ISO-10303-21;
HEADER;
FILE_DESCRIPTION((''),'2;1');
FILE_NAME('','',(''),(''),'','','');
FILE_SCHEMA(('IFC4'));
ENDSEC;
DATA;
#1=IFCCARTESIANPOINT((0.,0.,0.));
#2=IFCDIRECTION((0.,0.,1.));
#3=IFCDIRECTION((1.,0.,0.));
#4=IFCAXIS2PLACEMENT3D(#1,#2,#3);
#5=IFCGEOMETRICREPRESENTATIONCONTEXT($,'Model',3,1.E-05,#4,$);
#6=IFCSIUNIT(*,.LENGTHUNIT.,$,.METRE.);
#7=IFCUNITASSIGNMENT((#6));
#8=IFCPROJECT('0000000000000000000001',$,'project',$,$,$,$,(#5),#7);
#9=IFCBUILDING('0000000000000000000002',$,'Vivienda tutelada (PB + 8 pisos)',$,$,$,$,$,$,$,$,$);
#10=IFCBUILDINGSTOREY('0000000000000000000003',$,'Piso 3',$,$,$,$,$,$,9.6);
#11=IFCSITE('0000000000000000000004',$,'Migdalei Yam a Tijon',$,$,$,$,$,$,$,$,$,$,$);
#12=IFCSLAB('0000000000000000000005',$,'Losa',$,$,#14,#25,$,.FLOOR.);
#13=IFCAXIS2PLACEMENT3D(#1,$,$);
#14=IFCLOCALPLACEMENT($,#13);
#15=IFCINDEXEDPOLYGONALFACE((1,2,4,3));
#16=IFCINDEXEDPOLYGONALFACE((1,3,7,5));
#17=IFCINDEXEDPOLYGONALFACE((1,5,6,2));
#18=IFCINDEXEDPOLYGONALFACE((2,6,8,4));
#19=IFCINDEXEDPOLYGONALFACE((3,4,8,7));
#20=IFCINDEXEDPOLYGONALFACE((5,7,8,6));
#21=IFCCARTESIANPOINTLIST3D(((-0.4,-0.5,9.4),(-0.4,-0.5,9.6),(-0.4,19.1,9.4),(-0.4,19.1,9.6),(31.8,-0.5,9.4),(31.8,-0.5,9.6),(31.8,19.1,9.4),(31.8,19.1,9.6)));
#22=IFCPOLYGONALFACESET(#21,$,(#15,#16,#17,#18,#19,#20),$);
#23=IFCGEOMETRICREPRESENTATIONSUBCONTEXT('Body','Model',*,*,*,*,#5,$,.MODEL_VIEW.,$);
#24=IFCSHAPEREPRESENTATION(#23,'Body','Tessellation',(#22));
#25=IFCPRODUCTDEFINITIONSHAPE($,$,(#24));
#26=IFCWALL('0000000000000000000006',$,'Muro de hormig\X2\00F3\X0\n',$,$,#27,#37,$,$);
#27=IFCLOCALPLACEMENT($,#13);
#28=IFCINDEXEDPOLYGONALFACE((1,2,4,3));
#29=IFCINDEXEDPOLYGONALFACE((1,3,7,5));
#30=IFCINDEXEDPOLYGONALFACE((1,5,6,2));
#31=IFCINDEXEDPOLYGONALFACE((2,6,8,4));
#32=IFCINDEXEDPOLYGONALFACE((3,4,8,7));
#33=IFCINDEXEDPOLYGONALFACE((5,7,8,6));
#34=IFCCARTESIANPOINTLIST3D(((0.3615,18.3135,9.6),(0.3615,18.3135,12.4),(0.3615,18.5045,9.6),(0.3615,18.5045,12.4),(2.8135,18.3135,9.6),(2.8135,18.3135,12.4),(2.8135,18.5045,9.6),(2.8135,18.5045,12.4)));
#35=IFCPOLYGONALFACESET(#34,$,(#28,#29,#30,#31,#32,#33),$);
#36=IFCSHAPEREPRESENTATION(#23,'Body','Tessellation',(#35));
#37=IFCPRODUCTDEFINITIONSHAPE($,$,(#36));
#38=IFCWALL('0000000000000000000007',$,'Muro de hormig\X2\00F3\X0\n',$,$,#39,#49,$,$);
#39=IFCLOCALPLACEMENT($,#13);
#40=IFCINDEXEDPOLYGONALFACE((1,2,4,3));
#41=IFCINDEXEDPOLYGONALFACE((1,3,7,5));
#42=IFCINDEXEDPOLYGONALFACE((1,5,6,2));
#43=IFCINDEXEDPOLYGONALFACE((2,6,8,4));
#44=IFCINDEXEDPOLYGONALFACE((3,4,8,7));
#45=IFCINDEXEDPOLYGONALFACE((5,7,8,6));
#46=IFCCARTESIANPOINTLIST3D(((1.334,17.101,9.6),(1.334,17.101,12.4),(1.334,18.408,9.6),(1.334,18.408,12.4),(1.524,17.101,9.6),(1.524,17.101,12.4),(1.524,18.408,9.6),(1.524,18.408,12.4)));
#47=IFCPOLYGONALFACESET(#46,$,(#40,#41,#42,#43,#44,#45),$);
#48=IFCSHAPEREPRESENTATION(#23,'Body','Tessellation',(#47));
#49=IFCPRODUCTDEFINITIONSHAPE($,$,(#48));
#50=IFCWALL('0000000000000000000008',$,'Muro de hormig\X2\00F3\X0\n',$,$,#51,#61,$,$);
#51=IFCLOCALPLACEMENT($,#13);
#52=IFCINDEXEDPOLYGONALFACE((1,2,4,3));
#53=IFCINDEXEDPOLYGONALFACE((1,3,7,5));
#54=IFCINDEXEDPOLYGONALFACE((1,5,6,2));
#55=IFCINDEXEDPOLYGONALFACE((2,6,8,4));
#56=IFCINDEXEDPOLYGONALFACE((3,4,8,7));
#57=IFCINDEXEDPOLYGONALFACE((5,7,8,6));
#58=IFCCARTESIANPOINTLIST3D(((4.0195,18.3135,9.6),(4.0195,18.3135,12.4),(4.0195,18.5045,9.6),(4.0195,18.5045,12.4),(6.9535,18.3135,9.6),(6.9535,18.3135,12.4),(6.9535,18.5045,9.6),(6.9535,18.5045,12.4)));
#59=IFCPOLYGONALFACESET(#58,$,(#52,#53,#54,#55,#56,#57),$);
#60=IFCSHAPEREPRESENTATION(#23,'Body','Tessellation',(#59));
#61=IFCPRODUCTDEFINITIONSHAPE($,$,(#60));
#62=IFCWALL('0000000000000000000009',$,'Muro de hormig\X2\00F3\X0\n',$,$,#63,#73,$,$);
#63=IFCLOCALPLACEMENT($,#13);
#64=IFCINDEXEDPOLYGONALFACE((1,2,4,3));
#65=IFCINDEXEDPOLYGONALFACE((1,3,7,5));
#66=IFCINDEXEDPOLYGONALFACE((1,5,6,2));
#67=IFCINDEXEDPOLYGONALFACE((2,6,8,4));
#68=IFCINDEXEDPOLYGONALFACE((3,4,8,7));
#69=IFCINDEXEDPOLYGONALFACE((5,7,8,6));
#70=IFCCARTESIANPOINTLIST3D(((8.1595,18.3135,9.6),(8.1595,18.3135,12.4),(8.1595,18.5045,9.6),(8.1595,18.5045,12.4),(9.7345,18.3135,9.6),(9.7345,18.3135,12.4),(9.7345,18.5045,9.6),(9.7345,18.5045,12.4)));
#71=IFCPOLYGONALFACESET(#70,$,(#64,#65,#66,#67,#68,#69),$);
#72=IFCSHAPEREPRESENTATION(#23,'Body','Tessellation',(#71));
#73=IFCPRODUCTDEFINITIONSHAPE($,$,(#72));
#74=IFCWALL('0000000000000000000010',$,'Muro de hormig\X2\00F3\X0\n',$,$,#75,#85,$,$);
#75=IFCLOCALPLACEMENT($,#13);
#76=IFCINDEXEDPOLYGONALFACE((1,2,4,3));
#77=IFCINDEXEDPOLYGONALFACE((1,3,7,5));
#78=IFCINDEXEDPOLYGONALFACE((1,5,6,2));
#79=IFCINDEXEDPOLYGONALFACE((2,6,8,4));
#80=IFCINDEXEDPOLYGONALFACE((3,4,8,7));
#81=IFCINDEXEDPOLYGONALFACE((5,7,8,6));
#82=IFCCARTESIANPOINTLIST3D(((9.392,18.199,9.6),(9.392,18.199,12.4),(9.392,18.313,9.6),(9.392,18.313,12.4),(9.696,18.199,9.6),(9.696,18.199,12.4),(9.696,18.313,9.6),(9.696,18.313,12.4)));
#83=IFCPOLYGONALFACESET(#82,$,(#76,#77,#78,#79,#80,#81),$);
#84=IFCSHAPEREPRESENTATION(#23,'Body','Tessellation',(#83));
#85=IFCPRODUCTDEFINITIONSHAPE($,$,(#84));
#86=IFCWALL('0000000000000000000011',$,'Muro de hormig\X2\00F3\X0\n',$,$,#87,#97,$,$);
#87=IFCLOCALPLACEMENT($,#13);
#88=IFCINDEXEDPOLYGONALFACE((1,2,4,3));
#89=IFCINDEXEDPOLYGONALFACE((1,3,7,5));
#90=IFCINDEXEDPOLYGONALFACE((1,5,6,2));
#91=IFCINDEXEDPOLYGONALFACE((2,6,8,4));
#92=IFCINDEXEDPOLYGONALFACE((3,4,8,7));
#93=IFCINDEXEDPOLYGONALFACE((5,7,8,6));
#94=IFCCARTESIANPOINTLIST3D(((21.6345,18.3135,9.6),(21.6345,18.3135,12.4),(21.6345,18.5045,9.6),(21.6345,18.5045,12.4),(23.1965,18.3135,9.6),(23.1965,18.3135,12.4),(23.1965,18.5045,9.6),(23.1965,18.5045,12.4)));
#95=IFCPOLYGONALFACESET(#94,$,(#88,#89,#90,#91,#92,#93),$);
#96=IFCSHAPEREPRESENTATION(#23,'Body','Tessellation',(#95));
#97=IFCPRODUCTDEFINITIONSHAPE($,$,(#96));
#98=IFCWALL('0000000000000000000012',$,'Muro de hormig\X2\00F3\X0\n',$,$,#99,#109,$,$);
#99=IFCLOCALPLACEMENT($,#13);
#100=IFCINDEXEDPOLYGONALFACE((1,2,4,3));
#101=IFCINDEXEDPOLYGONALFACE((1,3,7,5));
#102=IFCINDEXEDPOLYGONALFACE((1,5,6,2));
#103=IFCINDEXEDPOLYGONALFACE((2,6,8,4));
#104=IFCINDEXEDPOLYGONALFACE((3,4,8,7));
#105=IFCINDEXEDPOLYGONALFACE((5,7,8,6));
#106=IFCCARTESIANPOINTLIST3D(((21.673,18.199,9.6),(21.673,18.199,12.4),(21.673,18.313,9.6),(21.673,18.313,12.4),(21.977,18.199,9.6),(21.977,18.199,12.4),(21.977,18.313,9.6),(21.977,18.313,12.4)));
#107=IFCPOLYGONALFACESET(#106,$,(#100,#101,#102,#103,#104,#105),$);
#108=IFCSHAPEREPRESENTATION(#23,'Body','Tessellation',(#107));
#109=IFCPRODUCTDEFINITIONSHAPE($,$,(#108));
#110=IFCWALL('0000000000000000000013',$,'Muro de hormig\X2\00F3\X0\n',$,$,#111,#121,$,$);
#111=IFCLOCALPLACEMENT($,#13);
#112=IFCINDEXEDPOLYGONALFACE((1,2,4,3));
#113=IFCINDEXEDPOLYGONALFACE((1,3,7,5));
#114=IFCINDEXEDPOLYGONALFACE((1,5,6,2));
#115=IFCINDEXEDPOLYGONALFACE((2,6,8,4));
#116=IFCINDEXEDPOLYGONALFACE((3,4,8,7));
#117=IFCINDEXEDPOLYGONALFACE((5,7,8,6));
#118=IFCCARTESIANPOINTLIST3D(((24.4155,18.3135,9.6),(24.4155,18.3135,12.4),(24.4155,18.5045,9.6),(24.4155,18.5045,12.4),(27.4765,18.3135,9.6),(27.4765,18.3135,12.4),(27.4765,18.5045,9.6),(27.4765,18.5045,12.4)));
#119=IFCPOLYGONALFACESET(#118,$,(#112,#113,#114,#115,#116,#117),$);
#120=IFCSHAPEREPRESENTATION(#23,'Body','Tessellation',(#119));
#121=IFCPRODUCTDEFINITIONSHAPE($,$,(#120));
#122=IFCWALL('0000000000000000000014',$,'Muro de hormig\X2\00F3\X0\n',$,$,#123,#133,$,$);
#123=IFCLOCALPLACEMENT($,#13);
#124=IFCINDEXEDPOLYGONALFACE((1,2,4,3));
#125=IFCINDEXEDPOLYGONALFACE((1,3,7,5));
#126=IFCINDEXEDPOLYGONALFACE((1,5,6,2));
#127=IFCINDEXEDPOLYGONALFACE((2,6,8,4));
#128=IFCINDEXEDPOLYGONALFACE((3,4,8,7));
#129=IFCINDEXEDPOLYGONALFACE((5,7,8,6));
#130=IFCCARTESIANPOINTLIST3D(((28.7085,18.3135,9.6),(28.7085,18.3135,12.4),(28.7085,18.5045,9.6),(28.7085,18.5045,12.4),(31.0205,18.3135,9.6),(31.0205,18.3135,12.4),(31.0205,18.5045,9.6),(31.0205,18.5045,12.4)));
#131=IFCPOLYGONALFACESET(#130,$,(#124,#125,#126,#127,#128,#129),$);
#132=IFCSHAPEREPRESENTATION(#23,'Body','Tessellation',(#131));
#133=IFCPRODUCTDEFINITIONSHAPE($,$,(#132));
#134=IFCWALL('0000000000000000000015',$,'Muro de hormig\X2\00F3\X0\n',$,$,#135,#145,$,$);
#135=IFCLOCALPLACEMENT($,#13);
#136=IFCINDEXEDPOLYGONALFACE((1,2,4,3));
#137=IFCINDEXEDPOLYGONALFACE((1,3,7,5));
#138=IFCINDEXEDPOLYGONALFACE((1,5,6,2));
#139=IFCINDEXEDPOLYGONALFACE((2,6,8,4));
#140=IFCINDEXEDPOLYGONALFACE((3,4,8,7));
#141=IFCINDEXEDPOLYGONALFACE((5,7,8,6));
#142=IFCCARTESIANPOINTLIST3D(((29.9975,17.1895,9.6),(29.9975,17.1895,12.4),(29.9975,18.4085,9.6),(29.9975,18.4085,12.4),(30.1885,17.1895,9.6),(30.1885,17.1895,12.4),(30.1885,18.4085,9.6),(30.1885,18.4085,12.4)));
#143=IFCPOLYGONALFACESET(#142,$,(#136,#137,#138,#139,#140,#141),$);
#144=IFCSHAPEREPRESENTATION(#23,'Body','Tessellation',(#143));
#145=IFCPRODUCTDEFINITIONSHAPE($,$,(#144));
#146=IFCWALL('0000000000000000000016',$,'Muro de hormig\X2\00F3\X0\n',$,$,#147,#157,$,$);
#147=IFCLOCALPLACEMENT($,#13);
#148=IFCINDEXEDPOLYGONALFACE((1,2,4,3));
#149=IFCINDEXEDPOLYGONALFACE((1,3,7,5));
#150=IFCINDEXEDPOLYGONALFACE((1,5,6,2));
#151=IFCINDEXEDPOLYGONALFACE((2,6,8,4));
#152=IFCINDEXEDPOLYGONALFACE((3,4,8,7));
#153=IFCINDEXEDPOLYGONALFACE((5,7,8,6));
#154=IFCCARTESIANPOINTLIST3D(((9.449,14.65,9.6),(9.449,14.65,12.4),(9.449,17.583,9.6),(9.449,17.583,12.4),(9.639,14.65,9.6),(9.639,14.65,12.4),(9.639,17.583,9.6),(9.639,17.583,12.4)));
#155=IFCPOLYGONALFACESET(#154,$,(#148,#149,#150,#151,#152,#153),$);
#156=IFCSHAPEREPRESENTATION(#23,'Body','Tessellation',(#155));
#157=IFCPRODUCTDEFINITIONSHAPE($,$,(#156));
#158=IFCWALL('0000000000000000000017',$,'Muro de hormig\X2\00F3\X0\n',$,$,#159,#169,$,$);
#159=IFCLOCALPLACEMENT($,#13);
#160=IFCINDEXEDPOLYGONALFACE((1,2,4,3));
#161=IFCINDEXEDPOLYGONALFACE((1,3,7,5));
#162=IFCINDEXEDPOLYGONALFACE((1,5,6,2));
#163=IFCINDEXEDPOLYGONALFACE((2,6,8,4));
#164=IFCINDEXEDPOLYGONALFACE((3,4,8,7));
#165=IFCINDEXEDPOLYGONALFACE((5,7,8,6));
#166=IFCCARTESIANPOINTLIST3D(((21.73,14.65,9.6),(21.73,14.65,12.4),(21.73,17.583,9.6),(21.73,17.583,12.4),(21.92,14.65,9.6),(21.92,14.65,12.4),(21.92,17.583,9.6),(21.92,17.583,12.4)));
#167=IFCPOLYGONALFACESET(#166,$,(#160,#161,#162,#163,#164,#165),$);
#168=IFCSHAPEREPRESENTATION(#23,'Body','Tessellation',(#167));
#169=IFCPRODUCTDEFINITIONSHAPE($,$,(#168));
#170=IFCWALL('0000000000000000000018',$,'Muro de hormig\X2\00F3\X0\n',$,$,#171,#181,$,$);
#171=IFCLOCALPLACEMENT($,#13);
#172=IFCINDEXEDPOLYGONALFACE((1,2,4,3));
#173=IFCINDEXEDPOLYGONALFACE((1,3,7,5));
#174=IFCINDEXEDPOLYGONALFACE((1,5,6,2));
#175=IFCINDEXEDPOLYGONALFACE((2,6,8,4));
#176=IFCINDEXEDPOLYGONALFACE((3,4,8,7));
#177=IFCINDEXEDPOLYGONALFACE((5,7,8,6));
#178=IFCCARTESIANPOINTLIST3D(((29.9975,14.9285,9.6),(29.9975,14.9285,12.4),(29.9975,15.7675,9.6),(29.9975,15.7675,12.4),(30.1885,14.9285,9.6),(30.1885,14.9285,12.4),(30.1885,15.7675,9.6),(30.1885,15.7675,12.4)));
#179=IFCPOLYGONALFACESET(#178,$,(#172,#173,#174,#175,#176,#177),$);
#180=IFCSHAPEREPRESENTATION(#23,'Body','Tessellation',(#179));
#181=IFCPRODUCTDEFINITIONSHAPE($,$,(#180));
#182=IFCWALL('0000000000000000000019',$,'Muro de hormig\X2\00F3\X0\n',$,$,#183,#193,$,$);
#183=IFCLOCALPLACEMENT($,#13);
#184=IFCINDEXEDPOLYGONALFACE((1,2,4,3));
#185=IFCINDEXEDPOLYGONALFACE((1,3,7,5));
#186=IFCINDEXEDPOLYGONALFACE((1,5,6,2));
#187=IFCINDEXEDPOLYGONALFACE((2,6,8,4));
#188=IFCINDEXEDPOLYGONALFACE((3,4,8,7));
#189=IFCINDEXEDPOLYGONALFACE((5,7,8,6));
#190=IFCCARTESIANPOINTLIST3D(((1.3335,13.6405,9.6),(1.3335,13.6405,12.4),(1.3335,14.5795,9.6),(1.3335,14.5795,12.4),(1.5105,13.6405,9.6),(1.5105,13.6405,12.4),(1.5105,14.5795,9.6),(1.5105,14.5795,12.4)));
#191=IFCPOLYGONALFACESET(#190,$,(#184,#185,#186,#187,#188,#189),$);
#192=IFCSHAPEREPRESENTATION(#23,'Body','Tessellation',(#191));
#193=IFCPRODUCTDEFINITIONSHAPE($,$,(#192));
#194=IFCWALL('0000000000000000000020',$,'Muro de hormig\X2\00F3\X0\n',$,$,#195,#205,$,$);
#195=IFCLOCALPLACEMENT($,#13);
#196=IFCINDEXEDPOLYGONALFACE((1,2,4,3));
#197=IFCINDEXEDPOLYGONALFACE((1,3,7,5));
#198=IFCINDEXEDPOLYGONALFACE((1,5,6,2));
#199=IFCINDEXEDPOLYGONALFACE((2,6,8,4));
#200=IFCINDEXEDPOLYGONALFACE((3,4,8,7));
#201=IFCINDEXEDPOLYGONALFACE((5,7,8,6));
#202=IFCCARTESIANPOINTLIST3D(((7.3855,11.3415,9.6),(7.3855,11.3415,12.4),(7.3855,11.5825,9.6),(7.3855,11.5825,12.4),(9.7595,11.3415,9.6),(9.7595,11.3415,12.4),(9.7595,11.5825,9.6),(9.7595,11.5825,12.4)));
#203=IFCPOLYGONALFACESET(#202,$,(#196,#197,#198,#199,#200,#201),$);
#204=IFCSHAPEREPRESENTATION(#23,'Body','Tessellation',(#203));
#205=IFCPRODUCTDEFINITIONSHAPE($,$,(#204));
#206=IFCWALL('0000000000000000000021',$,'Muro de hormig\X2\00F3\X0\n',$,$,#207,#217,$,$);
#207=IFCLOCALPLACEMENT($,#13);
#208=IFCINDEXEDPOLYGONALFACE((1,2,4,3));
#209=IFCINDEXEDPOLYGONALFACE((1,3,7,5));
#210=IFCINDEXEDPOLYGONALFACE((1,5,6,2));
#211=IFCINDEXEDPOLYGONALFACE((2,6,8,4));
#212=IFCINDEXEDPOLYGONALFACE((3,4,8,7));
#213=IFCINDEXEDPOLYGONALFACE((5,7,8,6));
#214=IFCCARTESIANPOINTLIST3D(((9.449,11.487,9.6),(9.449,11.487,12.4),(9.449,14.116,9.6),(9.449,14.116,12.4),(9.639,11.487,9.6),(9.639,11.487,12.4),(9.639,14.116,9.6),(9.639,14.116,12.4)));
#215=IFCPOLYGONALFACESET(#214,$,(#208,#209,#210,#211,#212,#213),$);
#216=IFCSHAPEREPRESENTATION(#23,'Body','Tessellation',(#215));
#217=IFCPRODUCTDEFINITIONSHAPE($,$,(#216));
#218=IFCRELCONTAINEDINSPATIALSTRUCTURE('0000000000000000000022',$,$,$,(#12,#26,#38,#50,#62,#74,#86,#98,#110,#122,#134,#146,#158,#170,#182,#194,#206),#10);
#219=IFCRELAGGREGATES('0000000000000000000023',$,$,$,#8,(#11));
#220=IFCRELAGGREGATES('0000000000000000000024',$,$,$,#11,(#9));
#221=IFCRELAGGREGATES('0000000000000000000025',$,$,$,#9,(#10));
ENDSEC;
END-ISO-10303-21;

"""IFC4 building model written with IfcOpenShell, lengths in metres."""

from ifc_helpers import new_model, si_unit, frame, origin_with_axes, context, subcontext, project, spatial, line, indexed_curve, outline, extrude, element, save


model = new_model("IFC4")

# Units and contexts
model_context = context("Model", 3, precision=1e-05, world=origin_with_axes())
body_context = subcontext(model_context, "Body", "Model", "MODEL_VIEW")
ifc_project = project(units=[si_unit("LENGTHUNIT", "METRE")], contexts=[model_context])

# Site, building, storey
site = spatial("IfcSite", under=ifc_project, Name="Migdalei Yam a Tijon")
building = spatial("IfcBuilding", under=site, Name="Vivienda tutelada (PB + 8 pisos)")
storey = spatial("IfcBuildingStorey", under=building, Name="Piso 3", Elevation=9.6)

# Slab
element("IfcSlab", 1, inside=storey, Name="Losa", PredefinedType="FLOOR", context=body_context, shape_type="SweptSolid", body=[
    extrude(outline(indexed_curve([(0.0, 0.0), (32.2, 0.0), (32.2, 19.6), (0.0, 19.6)], segments=[line(1, 2, 3, 4, 1)])), frame((-0.4, -0.5, 9.4), z_axis=(0.0, 0.0, 1.0), x_axis=(1.0, 0.0, 0.0)), (0.0, 0.0, 1.0), 0.2),
])

# Walls
element("IfcWall", 2, inside=storey, Name="Muro de hormigón", context=body_context, shape_type="SweptSolid", body=[
    extrude(outline(indexed_curve([(0.0, 0.0), (2.452, 0.0), (2.452, 0.191), (0.0, 0.191)], segments=[line(1, 2, 3, 4, 1)])), frame((0.3615, 18.3135, 9.6), z_axis=(0.0, 0.0, 1.0), x_axis=(1.0, 0.0, 0.0)), (0.0, 0.0, 1.0), 2.8),
])
element("IfcWall", 3, inside=storey, Name="Muro de hormigón", context=body_context, shape_type="SweptSolid", body=[
    extrude(outline(indexed_curve([(0.0, 0.0), (0.19, 0.0), (0.19, 1.307), (0.0, 1.307)], segments=[line(1, 2, 3, 4, 1)])), frame((1.334, 17.101, 9.6), z_axis=(0.0, 0.0, 1.0), x_axis=(1.0, 0.0, 0.0)), (0.0, 0.0, 1.0), 2.8),
])
element("IfcWall", 4, inside=storey, Name="Muro de hormigón", context=body_context, shape_type="SweptSolid", body=[
    extrude(outline(indexed_curve([(0.0, 0.0), (2.934, 0.0), (2.934, 0.191), (0.0, 0.191)], segments=[line(1, 2, 3, 4, 1)])), frame((4.0195, 18.3135, 9.6), z_axis=(0.0, 0.0, 1.0), x_axis=(1.0, 0.0, 0.0)), (0.0, 0.0, 1.0), 2.8),
])
element("IfcWall", 5, inside=storey, Name="Muro de hormigón", context=body_context, shape_type="SweptSolid", body=[
    extrude(outline(indexed_curve([(0.0, 0.0), (1.575, 0.0), (1.575, 0.191), (0.0, 0.191)], segments=[line(1, 2, 3, 4, 1)])), frame((8.1595, 18.3135, 9.6), z_axis=(0.0, 0.0, 1.0), x_axis=(1.0, 0.0, 0.0)), (0.0, 0.0, 1.0), 2.8),
])
element("IfcWall", 6, inside=storey, Name="Muro de hormigón", context=body_context, shape_type="SweptSolid", body=[
    extrude(outline(indexed_curve([(0.0, 0.0), (0.304, 0.0), (0.304, 0.114), (0.0, 0.114)], segments=[line(1, 2, 3, 4, 1)])), frame((9.392, 18.199, 9.6), z_axis=(0.0, 0.0, 1.0), x_axis=(1.0, 0.0, 0.0)), (0.0, 0.0, 1.0), 2.8),
])
element("IfcWall", 7, inside=storey, Name="Muro de hormigón", context=body_context, shape_type="SweptSolid", body=[
    extrude(outline(indexed_curve([(0.0, 0.0), (1.562, 0.0), (1.562, 0.191), (0.0, 0.191)], segments=[line(1, 2, 3, 4, 1)])), frame((21.6345, 18.3135, 9.6), z_axis=(0.0, 0.0, 1.0), x_axis=(1.0, 0.0, 0.0)), (0.0, 0.0, 1.0), 2.8),
])
element("IfcWall", 8, inside=storey, Name="Muro de hormigón", context=body_context, shape_type="SweptSolid", body=[
    extrude(outline(indexed_curve([(0.0, 0.0), (0.304, 0.0), (0.304, 0.114), (0.0, 0.114)], segments=[line(1, 2, 3, 4, 1)])), frame((21.673, 18.199, 9.6), z_axis=(0.0, 0.0, 1.0), x_axis=(1.0, 0.0, 0.0)), (0.0, 0.0, 1.0), 2.8),
])
element("IfcWall", 9, inside=storey, Name="Muro de hormigón", context=body_context, shape_type="SweptSolid", body=[
    extrude(outline(indexed_curve([(0.0, 0.0), (3.061, 0.0), (3.061, 0.191), (0.0, 0.191)], segments=[line(1, 2, 3, 4, 1)])), frame((24.4155, 18.3135, 9.6), z_axis=(0.0, 0.0, 1.0), x_axis=(1.0, 0.0, 0.0)), (0.0, 0.0, 1.0), 2.8),
])
element("IfcWall", 10, inside=storey, Name="Muro de hormigón", context=body_context, shape_type="SweptSolid", body=[
    extrude(outline(indexed_curve([(0.0, 0.0), (2.312, 0.0), (2.312, 0.191), (0.0, 0.191)], segments=[line(1, 2, 3, 4, 1)])), frame((28.7085, 18.3135, 9.6), z_axis=(0.0, 0.0, 1.0), x_axis=(1.0, 0.0, 0.0)), (0.0, 0.0, 1.0), 2.8),
])
element("IfcWall", 11, inside=storey, Name="Muro de hormigón", context=body_context, shape_type="SweptSolid", body=[
    extrude(outline(indexed_curve([(0.0, 0.0), (0.191, 0.0), (0.191, 1.219), (0.0, 1.219)], segments=[line(1, 2, 3, 4, 1)])), frame((29.9975, 17.1895, 9.6), z_axis=(0.0, 0.0, 1.0), x_axis=(1.0, 0.0, 0.0)), (0.0, 0.0, 1.0), 2.8),
])
element("IfcWall", 12, inside=storey, Name="Muro de hormigón", context=body_context, shape_type="SweptSolid", body=[
    extrude(outline(indexed_curve([(0.0, 0.0), (0.19, 0.0), (0.19, 2.933), (0.0, 2.933)], segments=[line(1, 2, 3, 4, 1)])), frame((9.449, 14.65, 9.6), z_axis=(0.0, 0.0, 1.0), x_axis=(1.0, 0.0, 0.0)), (0.0, 0.0, 1.0), 2.8),
])
element("IfcWall", 13, inside=storey, Name="Muro de hormigón", context=body_context, shape_type="SweptSolid", body=[
    extrude(outline(indexed_curve([(0.0, 0.0), (0.19, 0.0), (0.19, 2.933), (0.0, 2.933)], segments=[line(1, 2, 3, 4, 1)])), frame((21.73, 14.65, 9.6), z_axis=(0.0, 0.0, 1.0), x_axis=(1.0, 0.0, 0.0)), (0.0, 0.0, 1.0), 2.8),
])
element("IfcWall", 14, inside=storey, Name="Muro de hormigón", context=body_context, shape_type="SweptSolid", body=[
    extrude(outline(indexed_curve([(0.0, 0.0), (0.191, 0.0), (0.191, 0.839), (0.0, 0.839)], segments=[line(1, 2, 3, 4, 1)])), frame((29.9975, 14.9285, 9.6), z_axis=(0.0, 0.0, 1.0), x_axis=(1.0, 0.0, 0.0)), (0.0, 0.0, 1.0), 2.8),
])
element("IfcWall", 15, inside=storey, Name="Muro de hormigón", context=body_context, shape_type="SweptSolid", body=[
    extrude(outline(indexed_curve([(0.0, 0.0), (0.177, 0.0), (0.177, 0.939), (0.0, 0.939)], segments=[line(1, 2, 3, 4, 1)])), frame((1.3335, 13.6405, 9.6), z_axis=(0.0, 0.0, 1.0), x_axis=(1.0, 0.0, 0.0)), (0.0, 0.0, 1.0), 2.8),
])
element("IfcWall", 16, inside=storey, Name="Muro de hormigón", context=body_context, shape_type="SweptSolid", body=[
    extrude(outline(indexed_curve([(0.0, 0.0), (2.374, 0.0), (2.374, 0.241), (0.0, 0.241)], segments=[line(1, 2, 3, 4, 1)])), frame((7.3855, 11.3415, 9.6), z_axis=(0.0, 0.0, 1.0), x_axis=(1.0, 0.0, 0.0)), (0.0, 0.0, 1.0), 2.8),
])
element("IfcWall", 17, inside=storey, Name="Muro de hormigón", context=body_context, shape_type="SweptSolid", body=[
    extrude(outline(indexed_curve([(0.0, 0.0), (0.19, 0.0), (0.19, 2.629), (0.0, 2.629)], segments=[line(1, 2, 3, 4, 1)])), frame((9.449, 11.487, 9.6), z_axis=(0.0, 0.0, 1.0), x_axis=(1.0, 0.0, 0.0)), (0.0, 0.0, 1.0), 2.8),
])

save(model, "model.ifc")
